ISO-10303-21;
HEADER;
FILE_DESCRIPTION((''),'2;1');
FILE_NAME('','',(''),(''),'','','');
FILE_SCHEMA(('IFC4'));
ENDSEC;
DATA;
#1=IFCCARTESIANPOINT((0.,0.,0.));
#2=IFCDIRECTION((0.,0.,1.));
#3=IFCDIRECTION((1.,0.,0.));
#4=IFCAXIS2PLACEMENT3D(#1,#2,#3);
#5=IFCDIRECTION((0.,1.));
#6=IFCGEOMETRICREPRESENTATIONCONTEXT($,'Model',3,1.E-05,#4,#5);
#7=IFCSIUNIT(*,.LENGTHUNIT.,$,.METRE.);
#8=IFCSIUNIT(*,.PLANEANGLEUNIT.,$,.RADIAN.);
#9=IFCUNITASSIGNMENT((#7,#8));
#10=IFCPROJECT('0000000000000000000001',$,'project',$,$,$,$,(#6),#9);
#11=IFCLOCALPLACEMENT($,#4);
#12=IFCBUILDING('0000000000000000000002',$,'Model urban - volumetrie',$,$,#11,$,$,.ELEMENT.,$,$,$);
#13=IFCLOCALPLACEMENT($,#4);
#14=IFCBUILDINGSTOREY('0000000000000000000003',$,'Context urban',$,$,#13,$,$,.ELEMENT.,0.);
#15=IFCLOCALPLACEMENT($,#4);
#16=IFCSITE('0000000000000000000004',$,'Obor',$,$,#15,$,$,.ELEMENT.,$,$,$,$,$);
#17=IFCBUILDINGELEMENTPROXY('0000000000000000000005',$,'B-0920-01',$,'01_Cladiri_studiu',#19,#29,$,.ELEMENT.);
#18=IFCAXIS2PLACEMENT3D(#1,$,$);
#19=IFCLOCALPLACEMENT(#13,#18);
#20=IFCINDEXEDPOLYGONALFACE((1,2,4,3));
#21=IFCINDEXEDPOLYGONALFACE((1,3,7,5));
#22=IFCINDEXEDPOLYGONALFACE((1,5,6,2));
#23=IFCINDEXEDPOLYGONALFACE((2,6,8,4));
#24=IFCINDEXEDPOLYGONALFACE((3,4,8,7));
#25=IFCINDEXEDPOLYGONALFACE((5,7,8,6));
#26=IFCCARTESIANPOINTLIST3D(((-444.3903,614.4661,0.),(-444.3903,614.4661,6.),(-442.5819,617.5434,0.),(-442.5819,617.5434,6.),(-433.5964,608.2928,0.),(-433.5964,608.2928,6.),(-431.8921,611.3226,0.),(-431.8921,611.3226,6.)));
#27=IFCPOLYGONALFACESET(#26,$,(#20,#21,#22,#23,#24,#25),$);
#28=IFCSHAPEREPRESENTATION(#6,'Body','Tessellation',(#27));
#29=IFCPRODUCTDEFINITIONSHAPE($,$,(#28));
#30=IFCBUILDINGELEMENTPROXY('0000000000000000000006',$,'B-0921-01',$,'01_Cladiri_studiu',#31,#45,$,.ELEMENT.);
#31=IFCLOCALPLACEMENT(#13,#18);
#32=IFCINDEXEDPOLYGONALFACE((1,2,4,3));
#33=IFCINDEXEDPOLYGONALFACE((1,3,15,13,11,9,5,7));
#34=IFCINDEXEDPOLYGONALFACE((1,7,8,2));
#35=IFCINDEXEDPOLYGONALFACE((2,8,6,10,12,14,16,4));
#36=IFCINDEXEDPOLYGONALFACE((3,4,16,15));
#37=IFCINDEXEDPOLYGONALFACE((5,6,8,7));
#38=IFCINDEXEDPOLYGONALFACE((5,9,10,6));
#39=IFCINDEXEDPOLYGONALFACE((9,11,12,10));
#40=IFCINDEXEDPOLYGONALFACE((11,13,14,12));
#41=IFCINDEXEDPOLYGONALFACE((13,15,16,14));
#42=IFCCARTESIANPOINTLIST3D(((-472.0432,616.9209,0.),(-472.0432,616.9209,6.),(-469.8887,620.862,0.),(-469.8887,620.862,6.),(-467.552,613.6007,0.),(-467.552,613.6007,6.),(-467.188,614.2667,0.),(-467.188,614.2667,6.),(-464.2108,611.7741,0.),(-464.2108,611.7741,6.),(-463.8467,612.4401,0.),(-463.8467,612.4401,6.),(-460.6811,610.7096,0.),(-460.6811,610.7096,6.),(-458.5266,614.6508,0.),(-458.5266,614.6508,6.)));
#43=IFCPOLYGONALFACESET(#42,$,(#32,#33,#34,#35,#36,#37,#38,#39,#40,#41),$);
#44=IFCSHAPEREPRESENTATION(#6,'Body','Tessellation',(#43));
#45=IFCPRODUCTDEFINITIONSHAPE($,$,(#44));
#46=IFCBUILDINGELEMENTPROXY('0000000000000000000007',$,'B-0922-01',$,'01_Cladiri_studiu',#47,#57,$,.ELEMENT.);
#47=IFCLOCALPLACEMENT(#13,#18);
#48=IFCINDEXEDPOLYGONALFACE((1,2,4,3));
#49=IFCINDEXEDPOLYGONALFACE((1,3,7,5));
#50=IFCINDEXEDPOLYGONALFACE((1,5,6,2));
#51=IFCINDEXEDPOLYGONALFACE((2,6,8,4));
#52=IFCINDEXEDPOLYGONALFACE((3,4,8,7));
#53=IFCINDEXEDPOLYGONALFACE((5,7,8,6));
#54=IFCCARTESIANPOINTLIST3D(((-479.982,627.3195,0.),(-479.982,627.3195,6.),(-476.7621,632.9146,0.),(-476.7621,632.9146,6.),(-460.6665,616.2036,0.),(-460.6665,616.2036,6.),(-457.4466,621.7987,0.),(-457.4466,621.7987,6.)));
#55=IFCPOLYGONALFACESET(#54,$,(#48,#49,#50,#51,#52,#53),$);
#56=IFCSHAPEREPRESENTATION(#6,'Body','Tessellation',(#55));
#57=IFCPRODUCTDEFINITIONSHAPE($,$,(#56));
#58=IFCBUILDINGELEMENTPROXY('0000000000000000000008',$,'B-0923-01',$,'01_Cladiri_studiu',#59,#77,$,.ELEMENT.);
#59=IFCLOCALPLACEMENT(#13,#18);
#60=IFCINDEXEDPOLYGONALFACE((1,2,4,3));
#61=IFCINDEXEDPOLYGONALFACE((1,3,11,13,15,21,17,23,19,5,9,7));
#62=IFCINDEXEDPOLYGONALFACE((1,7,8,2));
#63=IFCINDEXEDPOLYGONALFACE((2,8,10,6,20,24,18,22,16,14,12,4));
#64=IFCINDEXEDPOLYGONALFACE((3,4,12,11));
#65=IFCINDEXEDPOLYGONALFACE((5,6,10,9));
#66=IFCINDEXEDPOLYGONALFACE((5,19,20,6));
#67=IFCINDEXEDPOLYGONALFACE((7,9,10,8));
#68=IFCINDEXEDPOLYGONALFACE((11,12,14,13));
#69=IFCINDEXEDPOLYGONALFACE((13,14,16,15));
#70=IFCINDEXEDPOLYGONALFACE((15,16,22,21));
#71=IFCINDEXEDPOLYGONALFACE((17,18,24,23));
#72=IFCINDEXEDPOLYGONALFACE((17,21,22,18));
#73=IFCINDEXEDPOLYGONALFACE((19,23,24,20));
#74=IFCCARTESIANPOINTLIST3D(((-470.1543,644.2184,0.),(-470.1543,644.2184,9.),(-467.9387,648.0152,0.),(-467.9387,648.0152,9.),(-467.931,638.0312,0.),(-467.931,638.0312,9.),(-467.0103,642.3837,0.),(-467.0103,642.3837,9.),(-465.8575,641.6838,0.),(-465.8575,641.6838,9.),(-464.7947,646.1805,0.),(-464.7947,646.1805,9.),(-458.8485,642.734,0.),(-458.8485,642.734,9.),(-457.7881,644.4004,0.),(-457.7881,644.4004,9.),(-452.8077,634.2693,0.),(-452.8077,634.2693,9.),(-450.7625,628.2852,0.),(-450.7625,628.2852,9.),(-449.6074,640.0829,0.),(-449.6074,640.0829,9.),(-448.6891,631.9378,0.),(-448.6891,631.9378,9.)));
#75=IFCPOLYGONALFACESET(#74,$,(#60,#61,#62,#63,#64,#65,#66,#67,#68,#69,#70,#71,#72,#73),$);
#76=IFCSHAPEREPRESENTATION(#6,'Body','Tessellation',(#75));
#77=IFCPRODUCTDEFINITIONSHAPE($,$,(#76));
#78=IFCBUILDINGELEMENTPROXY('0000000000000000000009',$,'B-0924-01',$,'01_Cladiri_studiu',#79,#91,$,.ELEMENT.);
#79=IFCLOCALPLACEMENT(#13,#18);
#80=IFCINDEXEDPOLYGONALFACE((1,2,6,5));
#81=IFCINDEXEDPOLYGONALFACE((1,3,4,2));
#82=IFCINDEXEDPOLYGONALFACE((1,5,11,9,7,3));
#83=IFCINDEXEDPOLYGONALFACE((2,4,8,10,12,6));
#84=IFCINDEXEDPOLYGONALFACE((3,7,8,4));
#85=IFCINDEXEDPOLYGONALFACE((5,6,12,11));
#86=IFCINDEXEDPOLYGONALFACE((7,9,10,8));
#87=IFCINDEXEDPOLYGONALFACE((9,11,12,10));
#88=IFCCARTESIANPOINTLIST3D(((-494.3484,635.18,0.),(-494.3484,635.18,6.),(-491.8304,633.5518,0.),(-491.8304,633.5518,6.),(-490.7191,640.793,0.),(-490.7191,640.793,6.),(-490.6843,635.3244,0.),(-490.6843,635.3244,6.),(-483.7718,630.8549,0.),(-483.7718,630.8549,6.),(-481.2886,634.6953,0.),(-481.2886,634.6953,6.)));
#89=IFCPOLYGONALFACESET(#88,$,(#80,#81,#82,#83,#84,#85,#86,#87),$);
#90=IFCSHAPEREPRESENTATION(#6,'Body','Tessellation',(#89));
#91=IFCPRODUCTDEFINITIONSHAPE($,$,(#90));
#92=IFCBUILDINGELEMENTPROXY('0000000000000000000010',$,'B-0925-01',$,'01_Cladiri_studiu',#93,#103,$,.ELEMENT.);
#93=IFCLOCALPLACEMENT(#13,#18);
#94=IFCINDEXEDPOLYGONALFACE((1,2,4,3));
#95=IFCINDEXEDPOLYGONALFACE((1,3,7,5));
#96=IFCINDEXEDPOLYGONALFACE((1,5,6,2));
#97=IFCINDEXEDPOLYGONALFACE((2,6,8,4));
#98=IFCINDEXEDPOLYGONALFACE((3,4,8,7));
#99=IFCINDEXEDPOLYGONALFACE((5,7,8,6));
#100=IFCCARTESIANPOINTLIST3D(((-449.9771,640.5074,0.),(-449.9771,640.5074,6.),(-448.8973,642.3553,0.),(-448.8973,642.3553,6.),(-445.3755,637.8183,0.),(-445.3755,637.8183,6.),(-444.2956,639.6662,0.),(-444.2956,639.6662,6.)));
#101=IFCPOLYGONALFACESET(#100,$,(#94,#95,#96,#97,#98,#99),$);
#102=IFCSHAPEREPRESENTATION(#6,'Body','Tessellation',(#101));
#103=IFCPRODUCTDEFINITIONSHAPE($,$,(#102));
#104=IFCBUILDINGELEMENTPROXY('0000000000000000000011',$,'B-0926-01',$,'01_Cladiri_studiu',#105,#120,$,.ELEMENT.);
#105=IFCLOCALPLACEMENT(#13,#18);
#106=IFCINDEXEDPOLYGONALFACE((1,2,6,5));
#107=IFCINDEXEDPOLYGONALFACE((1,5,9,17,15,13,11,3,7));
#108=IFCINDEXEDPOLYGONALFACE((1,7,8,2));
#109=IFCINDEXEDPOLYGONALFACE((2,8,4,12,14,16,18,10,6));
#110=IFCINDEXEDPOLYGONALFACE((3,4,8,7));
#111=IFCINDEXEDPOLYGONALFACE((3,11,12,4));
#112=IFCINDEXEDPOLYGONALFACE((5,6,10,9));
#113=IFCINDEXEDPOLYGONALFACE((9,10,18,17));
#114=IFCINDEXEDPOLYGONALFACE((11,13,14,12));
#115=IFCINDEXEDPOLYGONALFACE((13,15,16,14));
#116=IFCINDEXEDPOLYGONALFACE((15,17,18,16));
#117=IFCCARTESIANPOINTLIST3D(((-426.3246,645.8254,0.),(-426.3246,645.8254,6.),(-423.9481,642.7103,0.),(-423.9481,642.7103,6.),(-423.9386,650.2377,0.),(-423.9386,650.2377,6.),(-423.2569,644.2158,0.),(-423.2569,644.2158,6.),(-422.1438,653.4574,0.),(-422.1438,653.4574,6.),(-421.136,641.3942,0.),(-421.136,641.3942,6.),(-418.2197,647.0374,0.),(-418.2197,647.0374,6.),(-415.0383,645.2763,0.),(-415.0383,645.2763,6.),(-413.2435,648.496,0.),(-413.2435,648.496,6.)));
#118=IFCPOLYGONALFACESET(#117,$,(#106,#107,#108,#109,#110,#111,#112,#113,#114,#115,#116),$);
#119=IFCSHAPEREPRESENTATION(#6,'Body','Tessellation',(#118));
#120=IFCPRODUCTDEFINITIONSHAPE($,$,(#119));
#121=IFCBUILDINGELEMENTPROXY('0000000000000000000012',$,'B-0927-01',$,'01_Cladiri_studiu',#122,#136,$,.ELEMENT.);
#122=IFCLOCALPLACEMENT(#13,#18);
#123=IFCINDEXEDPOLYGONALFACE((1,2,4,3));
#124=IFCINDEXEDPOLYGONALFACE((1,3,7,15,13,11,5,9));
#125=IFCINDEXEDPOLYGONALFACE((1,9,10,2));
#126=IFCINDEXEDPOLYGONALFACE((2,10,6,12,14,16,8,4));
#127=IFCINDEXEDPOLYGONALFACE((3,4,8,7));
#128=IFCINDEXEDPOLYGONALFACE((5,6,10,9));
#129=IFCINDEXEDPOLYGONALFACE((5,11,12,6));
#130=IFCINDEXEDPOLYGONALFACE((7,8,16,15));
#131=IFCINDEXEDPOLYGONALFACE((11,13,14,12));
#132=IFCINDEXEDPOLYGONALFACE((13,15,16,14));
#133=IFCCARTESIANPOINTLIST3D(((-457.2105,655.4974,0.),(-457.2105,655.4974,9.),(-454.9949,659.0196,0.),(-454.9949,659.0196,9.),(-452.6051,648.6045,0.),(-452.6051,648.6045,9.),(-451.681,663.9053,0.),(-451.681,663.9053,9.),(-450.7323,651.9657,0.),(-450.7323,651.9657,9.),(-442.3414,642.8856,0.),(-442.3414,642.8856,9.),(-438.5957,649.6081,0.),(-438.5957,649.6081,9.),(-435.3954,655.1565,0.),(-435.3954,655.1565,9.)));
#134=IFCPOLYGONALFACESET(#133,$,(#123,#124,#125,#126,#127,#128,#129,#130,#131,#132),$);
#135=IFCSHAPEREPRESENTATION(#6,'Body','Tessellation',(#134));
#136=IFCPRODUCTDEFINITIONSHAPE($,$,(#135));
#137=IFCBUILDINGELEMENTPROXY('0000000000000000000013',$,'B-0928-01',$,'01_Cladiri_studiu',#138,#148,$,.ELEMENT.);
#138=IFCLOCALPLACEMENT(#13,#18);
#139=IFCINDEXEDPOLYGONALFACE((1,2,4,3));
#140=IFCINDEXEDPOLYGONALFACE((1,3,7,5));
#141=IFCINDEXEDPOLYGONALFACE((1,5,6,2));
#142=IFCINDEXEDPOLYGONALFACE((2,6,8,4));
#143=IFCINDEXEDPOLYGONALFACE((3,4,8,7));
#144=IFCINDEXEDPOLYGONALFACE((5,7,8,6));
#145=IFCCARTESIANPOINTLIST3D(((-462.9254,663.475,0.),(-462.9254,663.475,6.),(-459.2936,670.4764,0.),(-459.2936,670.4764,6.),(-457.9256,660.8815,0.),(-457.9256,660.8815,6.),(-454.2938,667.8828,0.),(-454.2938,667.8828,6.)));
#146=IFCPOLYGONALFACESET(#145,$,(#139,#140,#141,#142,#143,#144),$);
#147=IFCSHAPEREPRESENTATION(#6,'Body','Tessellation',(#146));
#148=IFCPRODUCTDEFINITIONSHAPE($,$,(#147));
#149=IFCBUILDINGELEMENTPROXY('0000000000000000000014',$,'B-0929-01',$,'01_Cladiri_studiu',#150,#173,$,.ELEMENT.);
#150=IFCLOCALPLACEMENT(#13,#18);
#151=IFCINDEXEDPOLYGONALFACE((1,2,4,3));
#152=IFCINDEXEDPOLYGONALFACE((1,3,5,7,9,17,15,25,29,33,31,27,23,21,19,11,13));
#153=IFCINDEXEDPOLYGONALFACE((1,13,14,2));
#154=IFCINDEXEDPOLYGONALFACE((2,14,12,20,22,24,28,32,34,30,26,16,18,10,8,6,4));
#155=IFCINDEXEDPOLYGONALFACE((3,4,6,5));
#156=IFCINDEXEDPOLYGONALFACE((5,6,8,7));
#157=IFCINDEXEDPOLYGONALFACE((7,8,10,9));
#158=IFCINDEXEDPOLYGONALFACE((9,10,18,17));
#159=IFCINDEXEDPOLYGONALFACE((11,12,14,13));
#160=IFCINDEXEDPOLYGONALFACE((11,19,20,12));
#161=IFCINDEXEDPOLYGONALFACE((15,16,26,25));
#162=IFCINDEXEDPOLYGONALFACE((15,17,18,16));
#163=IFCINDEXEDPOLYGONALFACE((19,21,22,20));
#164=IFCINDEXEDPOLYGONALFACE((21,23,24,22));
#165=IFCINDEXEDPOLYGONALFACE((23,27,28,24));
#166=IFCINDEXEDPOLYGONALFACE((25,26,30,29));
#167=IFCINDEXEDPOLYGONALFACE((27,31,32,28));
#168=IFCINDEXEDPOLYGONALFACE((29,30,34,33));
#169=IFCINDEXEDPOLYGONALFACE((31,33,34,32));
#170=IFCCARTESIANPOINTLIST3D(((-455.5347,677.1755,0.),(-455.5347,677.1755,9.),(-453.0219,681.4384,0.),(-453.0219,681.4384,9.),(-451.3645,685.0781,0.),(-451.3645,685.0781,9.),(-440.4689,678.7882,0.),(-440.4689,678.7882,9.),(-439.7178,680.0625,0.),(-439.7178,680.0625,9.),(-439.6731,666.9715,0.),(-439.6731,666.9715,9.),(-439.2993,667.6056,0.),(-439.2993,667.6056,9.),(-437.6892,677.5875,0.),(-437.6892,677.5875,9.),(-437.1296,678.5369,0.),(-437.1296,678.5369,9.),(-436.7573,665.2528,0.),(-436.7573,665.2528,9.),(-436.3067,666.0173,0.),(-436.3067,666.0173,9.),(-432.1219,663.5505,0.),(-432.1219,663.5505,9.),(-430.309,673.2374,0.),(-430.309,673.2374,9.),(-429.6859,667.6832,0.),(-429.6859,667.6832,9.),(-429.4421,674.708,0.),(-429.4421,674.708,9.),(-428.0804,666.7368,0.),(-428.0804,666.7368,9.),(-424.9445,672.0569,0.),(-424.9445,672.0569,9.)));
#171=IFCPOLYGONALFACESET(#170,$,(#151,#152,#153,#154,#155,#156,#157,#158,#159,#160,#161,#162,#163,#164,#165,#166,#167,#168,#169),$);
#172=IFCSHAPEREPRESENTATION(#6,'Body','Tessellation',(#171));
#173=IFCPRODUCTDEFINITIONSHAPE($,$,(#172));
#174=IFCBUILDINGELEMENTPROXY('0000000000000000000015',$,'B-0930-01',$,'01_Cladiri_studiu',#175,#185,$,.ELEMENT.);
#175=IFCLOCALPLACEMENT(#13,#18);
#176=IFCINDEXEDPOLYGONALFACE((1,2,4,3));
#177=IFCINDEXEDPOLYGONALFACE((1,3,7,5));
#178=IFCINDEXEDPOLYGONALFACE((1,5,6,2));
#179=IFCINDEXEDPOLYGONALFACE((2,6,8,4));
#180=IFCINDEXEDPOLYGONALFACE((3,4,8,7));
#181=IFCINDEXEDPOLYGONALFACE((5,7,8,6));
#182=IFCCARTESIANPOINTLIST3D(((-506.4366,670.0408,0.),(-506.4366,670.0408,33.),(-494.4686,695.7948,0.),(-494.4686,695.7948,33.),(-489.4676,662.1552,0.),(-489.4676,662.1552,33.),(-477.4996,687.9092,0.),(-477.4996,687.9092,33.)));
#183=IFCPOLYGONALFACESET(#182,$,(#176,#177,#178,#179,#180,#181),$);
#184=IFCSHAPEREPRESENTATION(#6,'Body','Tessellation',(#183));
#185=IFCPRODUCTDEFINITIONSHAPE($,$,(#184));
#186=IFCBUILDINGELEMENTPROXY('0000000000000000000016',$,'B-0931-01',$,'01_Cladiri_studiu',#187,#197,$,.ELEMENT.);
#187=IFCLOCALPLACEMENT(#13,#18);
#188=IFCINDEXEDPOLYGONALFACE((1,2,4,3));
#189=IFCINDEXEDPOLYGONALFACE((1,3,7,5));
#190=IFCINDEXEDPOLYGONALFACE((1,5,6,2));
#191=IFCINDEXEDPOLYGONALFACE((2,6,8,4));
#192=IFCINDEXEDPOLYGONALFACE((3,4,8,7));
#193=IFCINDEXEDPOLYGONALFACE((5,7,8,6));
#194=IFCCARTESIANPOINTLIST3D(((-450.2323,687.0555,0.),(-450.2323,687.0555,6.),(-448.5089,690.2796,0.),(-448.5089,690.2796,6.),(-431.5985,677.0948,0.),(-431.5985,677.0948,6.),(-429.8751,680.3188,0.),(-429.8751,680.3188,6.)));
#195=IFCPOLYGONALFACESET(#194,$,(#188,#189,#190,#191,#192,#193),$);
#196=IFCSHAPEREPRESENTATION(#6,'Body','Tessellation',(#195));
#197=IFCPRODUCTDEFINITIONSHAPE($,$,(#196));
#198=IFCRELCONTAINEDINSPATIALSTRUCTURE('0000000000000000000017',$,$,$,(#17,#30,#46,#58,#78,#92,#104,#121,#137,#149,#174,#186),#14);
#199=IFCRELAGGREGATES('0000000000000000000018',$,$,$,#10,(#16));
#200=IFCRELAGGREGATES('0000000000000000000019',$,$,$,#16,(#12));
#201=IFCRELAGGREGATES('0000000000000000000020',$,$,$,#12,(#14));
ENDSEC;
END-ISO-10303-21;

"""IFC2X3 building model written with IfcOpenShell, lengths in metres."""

from ifc_helpers import new_model, si_unit, direction, origin_with_axes, place, context, project, spatial, polyline, outline, extrude, element, save


model = new_model("IFC2X3")

# Units and contexts
model_context = context("Model", 3, precision=1e-05, world=origin_with_axes(), true_north=direction((0.0, 1.0)))
ifc_project = project(units=[si_unit("LENGTHUNIT", "METRE"), si_unit("PLANEANGLEUNIT", "RADIAN")], contexts=[model_context])

# Site, building, storey
site_placement = place(None, origin_with_axes())
site = spatial("IfcSite", under=ifc_project, at=site_placement, Name="Obor", CompositionType="ELEMENT")
building_placement = place(None, origin_with_axes())
building = spatial("IfcBuilding", under=site, at=building_placement, Name="Model urban - volumetrie", CompositionType="ELEMENT")
storey_placement = place(None, origin_with_axes())
storey = spatial("IfcBuildingStorey", under=building, at=storey_placement, Name="Context urban", CompositionType="ELEMENT", Elevation=0.0)

# Building element proxies
proxy_1_placement = place(None, origin_with_axes())
element("IfcBuildingElementProxy", 1, at=proxy_1_placement, inside=storey, Name="B-0920-01", ObjectType="01_Cladiri_studiu", CompositionType="ELEMENT", context=model_context, shape_type="SweptSolid", body=[
    extrude(outline(polyline([(-433.5964, 608.2928), (-431.8921, 611.3226), (-442.5819, 617.5434), (-444.3903, 614.4661), (-433.5964, 608.2928)])), origin_with_axes(), (0.0, 0.0, 1.0), 6.0),
])
proxy_2_placement = place(None, origin_with_axes())
element("IfcBuildingElementProxy", 2, at=proxy_2_placement, inside=storey, Name="B-0921-01", ObjectType="01_Cladiri_studiu", CompositionType="ELEMENT", context=model_context, shape_type="SweptSolid", body=[
    extrude(outline(polyline([(-472.0432, 616.9209), (-467.188, 614.2667), (-467.552, 613.6007), (-464.2108, 611.7741), (-463.8467, 612.4401), (-460.6811, 610.7096), (-458.5266, 614.6508), (-469.8887, 620.862), (-472.0432, 616.9209)])), origin_with_axes(), (0.0, 0.0, 1.0), 6.0),
])
proxy_3_placement = place(None, origin_with_axes())
element("IfcBuildingElementProxy", 3, at=proxy_3_placement, inside=storey, Name="B-0922-01", ObjectType="01_Cladiri_studiu", CompositionType="ELEMENT", context=model_context, shape_type="SweptSolid", body=[
    extrude(outline(polyline([(-460.6665, 616.2036), (-457.4466, 621.7987), (-476.7621, 632.9146), (-479.982, 627.3195), (-460.6665, 616.2036)])), origin_with_axes(), (0.0, 0.0, 1.0), 6.0),
])
proxy_4_placement = place(None, origin_with_axes())
element("IfcBuildingElementProxy", 4, at=proxy_4_placement, inside=storey, Name="B-0923-01", ObjectType="01_Cladiri_studiu", CompositionType="ELEMENT", context=model_context, shape_type="SweptSolid", body=[
    extrude(outline(polyline([(-449.6074, 640.0829), (-457.7881, 644.4004), (-458.8485, 642.734), (-464.7947, 646.1805), (-467.9387, 648.0152), (-470.1543, 644.2184), (-467.0103, 642.3837), (-465.8575, 641.6838), (-467.931, 638.0312), (-450.7625, 628.2852), (-448.6891, 631.9378), (-452.8077, 634.2693), (-449.6074, 640.0829)])), origin_with_axes(), (0.0, 0.0, 1.0), 9.0),
])
proxy_5_placement = place(None, origin_with_axes())
element("IfcBuildingElementProxy", 5, at=proxy_5_placement, inside=storey, Name="B-0924-01", ObjectType="01_Cladiri_studiu", CompositionType="ELEMENT", context=model_context, shape_type="SweptSolid", body=[
    extrude(outline(polyline([(-483.7718, 630.8549), (-481.2886, 634.6953), (-490.7191, 640.793), (-494.3484, 635.18), (-491.8304, 633.5518), (-490.6843, 635.3244), (-483.7718, 630.8549)])), origin_with_axes(), (0.0, 0.0, 1.0), 6.0),
])
proxy_6_placement = place(None, origin_with_axes())
element("IfcBuildingElementProxy", 6, at=proxy_6_placement, inside=storey, Name="B-0925-01", ObjectType="01_Cladiri_studiu", CompositionType="ELEMENT", context=model_context, shape_type="SweptSolid", body=[
    extrude(outline(polyline([(-449.9771, 640.5074), (-445.3755, 637.8183), (-444.2956, 639.6662), (-448.8973, 642.3553), (-449.9771, 640.5074)])), origin_with_axes(), (0.0, 0.0, 1.0), 6.0),
])
proxy_7_placement = place(None, origin_with_axes())
element("IfcBuildingElementProxy", 7, at=proxy_7_placement, inside=storey, Name="B-0926-01", ObjectType="01_Cladiri_studiu", CompositionType="ELEMENT", context=model_context, shape_type="SweptSolid", body=[
    extrude(outline(polyline([(-413.2435, 648.496), (-422.1438, 653.4574), (-423.9386, 650.2377), (-426.3246, 645.8254), (-423.2569, 644.2158), (-423.9481, 642.7103), (-421.136, 641.3942), (-418.2197, 647.0374), (-415.0383, 645.2763), (-413.2435, 648.496)])), origin_with_axes(), (0.0, 0.0, 1.0), 6.0),
])
proxy_8_placement = place(None, origin_with_axes())
element("IfcBuildingElementProxy", 8, at=proxy_8_placement, inside=storey, Name="B-0927-01", ObjectType="01_Cladiri_studiu", CompositionType="ELEMENT", context=model_context, shape_type="SweptSolid", body=[
    extrude(outline(polyline([(-457.2105, 655.4974), (-450.7323, 651.9657), (-452.6051, 648.6045), (-442.3414, 642.8856), (-438.5957, 649.6081), (-435.3954, 655.1565), (-451.681, 663.9053), (-454.9949, 659.0196), (-457.2105, 655.4974)])), origin_with_axes(), (0.0, 0.0, 1.0), 9.0),
])
proxy_9_placement = place(None, origin_with_axes())
element("IfcBuildingElementProxy", 9, at=proxy_9_placement, inside=storey, Name="B-0928-01", ObjectType="01_Cladiri_studiu", CompositionType="ELEMENT", context=model_context, shape_type="SweptSolid", body=[
    extrude(outline(polyline([(-457.9256, 660.8815), (-454.2938, 667.8828), (-459.2936, 670.4764), (-462.9254, 663.475), (-457.9256, 660.8815)])), origin_with_axes(), (0.0, 0.0, 1.0), 6.0),
])
proxy_10_placement = place(None, origin_with_axes())
element("IfcBuildingElementProxy", 10, at=proxy_10_placement, inside=storey, Name="B-0929-01", ObjectType="01_Cladiri_studiu", CompositionType="ELEMENT", context=model_context, shape_type="SweptSolid", body=[
    extrude(outline(polyline([(-429.4421, 674.708), (-430.309, 673.2374), (-437.6892, 677.5875), (-437.1296, 678.5369), (-439.7178, 680.0625), (-440.4689, 678.7882), (-451.3645, 685.0781), (-453.0219, 681.4384), (-455.5347, 677.1755), (-439.2993, 667.6056), (-439.6731, 666.9715), (-436.7573, 665.2528), (-436.3067, 666.0173), (-432.1219, 663.5505), (-429.6859, 667.6832), (-428.0804, 666.7368), (-424.9445, 672.0569), (-429.4421, 674.708)])), origin_with_axes(), (0.0, 0.0, 1.0), 9.0),
])
proxy_11_placement = place(None, origin_with_axes())
element("IfcBuildingElementProxy", 11, at=proxy_11_placement, inside=storey, Name="B-0930-01", ObjectType="01_Cladiri_studiu", CompositionType="ELEMENT", context=model_context, shape_type="SweptSolid", body=[
    extrude(outline(polyline([(-489.4676, 662.1552), (-477.4996, 687.9092), (-494.4686, 695.7948), (-506.4366, 670.0408), (-489.4676, 662.1552)])), origin_with_axes(), (0.0, 0.0, 1.0), 33.0),
])
proxy_12_placement = place(None, origin_with_axes())
element("IfcBuildingElementProxy", 12, at=proxy_12_placement, inside=storey, Name="B-0931-01", ObjectType="01_Cladiri_studiu", CompositionType="ELEMENT", context=model_context, shape_type="SweptSolid", body=[
    extrude(outline(polyline([(-429.8751, 680.3188), (-448.5089, 690.2796), (-450.2323, 687.0555), (-431.5985, 677.0948), (-429.8751, 680.3188)])), origin_with_axes(), (0.0, 0.0, 1.0), 6.0),
])

save(model, "model.ifc")
